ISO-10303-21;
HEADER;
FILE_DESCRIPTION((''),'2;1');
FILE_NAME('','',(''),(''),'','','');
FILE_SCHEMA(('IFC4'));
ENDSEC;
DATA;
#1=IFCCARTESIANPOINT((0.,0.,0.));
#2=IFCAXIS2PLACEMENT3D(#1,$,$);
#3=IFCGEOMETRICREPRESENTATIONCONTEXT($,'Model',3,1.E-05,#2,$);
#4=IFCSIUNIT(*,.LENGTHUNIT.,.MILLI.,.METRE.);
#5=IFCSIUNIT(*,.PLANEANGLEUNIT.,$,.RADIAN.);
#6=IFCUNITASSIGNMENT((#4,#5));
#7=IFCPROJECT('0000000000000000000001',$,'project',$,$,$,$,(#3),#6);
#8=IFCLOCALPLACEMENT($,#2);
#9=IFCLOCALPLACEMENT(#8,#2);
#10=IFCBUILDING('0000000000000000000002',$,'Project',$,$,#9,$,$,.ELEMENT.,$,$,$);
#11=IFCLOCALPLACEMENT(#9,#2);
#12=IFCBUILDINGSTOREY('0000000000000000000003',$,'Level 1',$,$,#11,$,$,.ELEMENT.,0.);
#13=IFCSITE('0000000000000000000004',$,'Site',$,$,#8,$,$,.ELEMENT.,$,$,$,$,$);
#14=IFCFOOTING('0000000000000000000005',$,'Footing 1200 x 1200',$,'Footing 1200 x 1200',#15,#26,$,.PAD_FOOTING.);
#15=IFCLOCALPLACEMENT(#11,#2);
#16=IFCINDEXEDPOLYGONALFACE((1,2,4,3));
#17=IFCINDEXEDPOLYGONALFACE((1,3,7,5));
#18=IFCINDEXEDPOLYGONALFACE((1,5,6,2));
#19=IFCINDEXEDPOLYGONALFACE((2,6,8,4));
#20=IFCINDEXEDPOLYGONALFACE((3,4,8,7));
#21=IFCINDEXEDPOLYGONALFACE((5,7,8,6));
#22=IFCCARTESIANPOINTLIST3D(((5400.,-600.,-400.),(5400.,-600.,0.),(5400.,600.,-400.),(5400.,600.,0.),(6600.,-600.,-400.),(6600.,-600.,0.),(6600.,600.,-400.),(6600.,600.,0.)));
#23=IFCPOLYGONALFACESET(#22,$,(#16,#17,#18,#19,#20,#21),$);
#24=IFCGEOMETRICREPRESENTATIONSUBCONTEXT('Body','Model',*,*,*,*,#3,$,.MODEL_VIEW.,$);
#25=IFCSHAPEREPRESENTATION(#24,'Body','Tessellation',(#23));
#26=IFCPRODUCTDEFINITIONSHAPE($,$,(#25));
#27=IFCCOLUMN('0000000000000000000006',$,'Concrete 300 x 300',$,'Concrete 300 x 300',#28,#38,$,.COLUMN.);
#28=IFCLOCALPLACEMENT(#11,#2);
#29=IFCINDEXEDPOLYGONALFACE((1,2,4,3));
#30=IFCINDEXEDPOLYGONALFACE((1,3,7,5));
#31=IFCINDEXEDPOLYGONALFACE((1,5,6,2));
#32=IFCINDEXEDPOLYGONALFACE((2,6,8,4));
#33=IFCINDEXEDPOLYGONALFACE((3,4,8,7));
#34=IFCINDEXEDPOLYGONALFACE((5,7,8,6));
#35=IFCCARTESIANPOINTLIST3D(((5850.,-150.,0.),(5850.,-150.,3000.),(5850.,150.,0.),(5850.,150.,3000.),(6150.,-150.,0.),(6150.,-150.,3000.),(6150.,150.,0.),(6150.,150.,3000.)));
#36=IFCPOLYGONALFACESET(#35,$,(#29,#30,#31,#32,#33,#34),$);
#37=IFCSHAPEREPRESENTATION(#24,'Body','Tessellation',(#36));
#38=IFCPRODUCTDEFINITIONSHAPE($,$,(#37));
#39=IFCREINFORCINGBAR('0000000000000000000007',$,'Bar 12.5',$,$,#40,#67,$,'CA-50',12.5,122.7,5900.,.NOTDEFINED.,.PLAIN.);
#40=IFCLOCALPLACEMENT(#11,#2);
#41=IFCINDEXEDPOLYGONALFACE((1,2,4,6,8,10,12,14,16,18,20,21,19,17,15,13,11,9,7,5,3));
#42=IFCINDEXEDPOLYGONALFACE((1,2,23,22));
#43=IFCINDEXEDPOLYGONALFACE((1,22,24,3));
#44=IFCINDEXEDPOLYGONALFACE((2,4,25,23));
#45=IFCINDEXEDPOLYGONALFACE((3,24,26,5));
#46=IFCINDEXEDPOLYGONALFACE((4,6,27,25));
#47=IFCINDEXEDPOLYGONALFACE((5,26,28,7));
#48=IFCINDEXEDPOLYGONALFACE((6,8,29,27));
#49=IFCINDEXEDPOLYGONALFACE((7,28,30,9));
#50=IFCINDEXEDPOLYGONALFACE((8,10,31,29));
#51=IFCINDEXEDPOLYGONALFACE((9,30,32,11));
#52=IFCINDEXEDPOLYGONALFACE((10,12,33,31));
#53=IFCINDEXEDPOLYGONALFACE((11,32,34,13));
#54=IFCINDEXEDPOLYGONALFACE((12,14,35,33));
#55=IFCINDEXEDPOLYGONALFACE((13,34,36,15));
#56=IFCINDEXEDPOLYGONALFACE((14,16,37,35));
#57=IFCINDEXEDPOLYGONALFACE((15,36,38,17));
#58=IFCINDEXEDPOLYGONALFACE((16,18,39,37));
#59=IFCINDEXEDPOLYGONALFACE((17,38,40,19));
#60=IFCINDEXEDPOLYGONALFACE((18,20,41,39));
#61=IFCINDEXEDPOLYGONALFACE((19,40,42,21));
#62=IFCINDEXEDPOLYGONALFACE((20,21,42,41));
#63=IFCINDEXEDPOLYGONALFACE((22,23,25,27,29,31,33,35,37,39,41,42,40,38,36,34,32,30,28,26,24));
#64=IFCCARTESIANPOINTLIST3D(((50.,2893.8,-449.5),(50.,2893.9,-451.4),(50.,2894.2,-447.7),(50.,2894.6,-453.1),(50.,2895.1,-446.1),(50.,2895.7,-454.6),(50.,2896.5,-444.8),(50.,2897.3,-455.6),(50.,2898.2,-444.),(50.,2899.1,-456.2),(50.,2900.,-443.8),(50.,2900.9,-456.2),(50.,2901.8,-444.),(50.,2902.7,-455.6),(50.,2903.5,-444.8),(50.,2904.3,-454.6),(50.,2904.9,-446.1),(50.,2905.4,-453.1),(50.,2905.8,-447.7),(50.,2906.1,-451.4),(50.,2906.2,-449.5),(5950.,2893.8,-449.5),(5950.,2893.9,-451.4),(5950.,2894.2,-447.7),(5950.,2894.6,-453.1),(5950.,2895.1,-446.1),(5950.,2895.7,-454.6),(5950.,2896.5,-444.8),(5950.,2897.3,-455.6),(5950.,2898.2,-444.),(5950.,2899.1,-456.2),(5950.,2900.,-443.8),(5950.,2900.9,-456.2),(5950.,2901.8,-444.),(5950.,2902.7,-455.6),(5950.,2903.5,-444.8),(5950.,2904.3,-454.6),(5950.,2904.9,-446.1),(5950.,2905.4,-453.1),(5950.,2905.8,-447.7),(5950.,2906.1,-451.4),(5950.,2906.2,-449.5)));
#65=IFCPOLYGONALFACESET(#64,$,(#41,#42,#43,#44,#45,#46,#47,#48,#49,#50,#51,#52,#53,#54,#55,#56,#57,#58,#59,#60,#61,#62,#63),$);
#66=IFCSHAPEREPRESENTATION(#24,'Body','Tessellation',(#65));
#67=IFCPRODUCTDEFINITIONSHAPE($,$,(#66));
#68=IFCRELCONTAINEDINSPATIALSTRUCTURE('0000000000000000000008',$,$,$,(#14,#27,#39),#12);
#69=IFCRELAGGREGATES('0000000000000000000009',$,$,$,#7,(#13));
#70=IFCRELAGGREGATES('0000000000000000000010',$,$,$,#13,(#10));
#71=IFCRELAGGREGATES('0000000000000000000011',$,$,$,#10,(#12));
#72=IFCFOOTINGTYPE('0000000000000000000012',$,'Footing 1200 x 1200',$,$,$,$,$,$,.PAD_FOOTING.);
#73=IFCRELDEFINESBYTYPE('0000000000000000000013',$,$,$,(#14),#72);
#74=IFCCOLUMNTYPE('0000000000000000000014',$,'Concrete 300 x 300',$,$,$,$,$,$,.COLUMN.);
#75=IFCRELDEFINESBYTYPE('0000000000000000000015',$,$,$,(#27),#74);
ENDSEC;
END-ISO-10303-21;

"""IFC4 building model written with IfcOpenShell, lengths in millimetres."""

from ifc_helpers import new_model, entity, si_unit, frame, origin, origin_2d, place, context, subcontext, project, spatial, rectangle, extrude, material_profile, profile_set, profile_usage, type_object, element, save


model = new_model("IFC4")

# Units and contexts
model_context = context("Model", 3, precision=1e-05, world=origin())
body_context = subcontext(model_context, "Body", "Model", "MODEL_VIEW")
ifc_project = project(units=[si_unit("LENGTHUNIT", "METRE", prefix="MILLI"), si_unit("PLANEANGLEUNIT", "RADIAN")], contexts=[model_context])

# Site, building, storey
site_placement = place(None, origin())
site = spatial("IfcSite", under=ifc_project, at=site_placement, Name="Site", CompositionType="ELEMENT")
building_placement = place(site_placement, origin())
building = spatial("IfcBuilding", under=site, at=building_placement, Name="Project", CompositionType="ELEMENT")
storey_placement = place(building_placement, origin())
storey = spatial("IfcBuildingStorey", under=building, at=storey_placement, Name="Level 1", CompositionType="ELEMENT", Elevation=0.0)

# Footing
ifc_material_profile_1 = material_profile(None, rectangle(XDim=1200.0, YDim=1200.0, at=origin_2d()), Name="Footing 1200 x 1200")
ifc_profile_set_1 = profile_set([ifc_material_profile_1], Name="Footing 1200 x 1200")
ifc_profile_usage_1 = profile_usage(ifc_profile_set_1, cardinal=5)
footing_type = type_object("IfcFootingType", Name="Footing 1200 x 1200", PredefinedType="PAD_FOOTING", material=ifc_profile_set_1)
footing_placement = place(storey_placement, frame((6000.0, 0.0, -400.0), z_axis=(0.0, 0.0, 1.0), x_axis=(1.0, 0.0, 0.0)))
element("IfcFooting", 1, at=footing_placement, inside=storey, type_object=footing_type, material=ifc_profile_usage_1, Name="Footing 1200 x 1200", ObjectType="Footing 1200 x 1200", PredefinedType="PAD_FOOTING", context=body_context, shape_type="SweptSolid", body=[
    extrude(rectangle(XDim=1200.0, YDim=1200.0, at=origin_2d()), origin(), (0.0, 0.0, 1.0), 400.0),
])

# Column
ifc_material_profile_2 = material_profile(None, rectangle(XDim=300.0, YDim=300.0, at=origin_2d()), Name="Concrete 300 x 300")
ifc_profile_set_2 = profile_set([ifc_material_profile_2], Name="Concrete 300 x 300")
ifc_profile_usage_2 = profile_usage(ifc_profile_set_2, cardinal=5)
column_type_1 = type_object("IfcColumnType", Name="Concrete 300 x 300", PredefinedType="COLUMN", material=ifc_profile_set_2)
column_1_placement = place(storey_placement, frame((6000.0, 0.0, 0.0), z_axis=(0.0, 0.0, 1.0), x_axis=(1.0, 0.0, 0.0)))
element("IfcColumn", 2, at=column_1_placement, inside=storey, type_object=column_type_1, material=ifc_profile_usage_2, Name="Concrete 300 x 300", ObjectType="Concrete 300 x 300", PredefinedType="COLUMN", context=body_context, shape_type="SweptSolid", body=[
    extrude(rectangle(XDim=300.0, YDim=300.0, at=origin_2d()), origin(), (0.0, 0.0, 1.0), 3000.0),
])

# Reinforcing bar
reinforcing_bar_1_placement = place(storey_placement, origin())
element("IfcReinforcingBar", 3, at=reinforcing_bar_1_placement, inside=storey, Name="Bar 12.5", SteelGrade="CA-50", BarLength=5900.0, BarSurface="PLAIN", CrossSectionArea=122.7, NominalDiameter=12.5, PredefinedType="NOTDEFINED", context=body_context, shape_type="AdvancedSweptSolid", body=[
    entity("IfcSweptDiskSolid", entity("IfcPolyline", [entity("IfcCartesianPoint", [50.0, 2900.0, -450.0]), entity("IfcCartesianPoint", [5950.0, 2900.0, -450.0])]), 6.2),
])

save(model, "model.ifc")
